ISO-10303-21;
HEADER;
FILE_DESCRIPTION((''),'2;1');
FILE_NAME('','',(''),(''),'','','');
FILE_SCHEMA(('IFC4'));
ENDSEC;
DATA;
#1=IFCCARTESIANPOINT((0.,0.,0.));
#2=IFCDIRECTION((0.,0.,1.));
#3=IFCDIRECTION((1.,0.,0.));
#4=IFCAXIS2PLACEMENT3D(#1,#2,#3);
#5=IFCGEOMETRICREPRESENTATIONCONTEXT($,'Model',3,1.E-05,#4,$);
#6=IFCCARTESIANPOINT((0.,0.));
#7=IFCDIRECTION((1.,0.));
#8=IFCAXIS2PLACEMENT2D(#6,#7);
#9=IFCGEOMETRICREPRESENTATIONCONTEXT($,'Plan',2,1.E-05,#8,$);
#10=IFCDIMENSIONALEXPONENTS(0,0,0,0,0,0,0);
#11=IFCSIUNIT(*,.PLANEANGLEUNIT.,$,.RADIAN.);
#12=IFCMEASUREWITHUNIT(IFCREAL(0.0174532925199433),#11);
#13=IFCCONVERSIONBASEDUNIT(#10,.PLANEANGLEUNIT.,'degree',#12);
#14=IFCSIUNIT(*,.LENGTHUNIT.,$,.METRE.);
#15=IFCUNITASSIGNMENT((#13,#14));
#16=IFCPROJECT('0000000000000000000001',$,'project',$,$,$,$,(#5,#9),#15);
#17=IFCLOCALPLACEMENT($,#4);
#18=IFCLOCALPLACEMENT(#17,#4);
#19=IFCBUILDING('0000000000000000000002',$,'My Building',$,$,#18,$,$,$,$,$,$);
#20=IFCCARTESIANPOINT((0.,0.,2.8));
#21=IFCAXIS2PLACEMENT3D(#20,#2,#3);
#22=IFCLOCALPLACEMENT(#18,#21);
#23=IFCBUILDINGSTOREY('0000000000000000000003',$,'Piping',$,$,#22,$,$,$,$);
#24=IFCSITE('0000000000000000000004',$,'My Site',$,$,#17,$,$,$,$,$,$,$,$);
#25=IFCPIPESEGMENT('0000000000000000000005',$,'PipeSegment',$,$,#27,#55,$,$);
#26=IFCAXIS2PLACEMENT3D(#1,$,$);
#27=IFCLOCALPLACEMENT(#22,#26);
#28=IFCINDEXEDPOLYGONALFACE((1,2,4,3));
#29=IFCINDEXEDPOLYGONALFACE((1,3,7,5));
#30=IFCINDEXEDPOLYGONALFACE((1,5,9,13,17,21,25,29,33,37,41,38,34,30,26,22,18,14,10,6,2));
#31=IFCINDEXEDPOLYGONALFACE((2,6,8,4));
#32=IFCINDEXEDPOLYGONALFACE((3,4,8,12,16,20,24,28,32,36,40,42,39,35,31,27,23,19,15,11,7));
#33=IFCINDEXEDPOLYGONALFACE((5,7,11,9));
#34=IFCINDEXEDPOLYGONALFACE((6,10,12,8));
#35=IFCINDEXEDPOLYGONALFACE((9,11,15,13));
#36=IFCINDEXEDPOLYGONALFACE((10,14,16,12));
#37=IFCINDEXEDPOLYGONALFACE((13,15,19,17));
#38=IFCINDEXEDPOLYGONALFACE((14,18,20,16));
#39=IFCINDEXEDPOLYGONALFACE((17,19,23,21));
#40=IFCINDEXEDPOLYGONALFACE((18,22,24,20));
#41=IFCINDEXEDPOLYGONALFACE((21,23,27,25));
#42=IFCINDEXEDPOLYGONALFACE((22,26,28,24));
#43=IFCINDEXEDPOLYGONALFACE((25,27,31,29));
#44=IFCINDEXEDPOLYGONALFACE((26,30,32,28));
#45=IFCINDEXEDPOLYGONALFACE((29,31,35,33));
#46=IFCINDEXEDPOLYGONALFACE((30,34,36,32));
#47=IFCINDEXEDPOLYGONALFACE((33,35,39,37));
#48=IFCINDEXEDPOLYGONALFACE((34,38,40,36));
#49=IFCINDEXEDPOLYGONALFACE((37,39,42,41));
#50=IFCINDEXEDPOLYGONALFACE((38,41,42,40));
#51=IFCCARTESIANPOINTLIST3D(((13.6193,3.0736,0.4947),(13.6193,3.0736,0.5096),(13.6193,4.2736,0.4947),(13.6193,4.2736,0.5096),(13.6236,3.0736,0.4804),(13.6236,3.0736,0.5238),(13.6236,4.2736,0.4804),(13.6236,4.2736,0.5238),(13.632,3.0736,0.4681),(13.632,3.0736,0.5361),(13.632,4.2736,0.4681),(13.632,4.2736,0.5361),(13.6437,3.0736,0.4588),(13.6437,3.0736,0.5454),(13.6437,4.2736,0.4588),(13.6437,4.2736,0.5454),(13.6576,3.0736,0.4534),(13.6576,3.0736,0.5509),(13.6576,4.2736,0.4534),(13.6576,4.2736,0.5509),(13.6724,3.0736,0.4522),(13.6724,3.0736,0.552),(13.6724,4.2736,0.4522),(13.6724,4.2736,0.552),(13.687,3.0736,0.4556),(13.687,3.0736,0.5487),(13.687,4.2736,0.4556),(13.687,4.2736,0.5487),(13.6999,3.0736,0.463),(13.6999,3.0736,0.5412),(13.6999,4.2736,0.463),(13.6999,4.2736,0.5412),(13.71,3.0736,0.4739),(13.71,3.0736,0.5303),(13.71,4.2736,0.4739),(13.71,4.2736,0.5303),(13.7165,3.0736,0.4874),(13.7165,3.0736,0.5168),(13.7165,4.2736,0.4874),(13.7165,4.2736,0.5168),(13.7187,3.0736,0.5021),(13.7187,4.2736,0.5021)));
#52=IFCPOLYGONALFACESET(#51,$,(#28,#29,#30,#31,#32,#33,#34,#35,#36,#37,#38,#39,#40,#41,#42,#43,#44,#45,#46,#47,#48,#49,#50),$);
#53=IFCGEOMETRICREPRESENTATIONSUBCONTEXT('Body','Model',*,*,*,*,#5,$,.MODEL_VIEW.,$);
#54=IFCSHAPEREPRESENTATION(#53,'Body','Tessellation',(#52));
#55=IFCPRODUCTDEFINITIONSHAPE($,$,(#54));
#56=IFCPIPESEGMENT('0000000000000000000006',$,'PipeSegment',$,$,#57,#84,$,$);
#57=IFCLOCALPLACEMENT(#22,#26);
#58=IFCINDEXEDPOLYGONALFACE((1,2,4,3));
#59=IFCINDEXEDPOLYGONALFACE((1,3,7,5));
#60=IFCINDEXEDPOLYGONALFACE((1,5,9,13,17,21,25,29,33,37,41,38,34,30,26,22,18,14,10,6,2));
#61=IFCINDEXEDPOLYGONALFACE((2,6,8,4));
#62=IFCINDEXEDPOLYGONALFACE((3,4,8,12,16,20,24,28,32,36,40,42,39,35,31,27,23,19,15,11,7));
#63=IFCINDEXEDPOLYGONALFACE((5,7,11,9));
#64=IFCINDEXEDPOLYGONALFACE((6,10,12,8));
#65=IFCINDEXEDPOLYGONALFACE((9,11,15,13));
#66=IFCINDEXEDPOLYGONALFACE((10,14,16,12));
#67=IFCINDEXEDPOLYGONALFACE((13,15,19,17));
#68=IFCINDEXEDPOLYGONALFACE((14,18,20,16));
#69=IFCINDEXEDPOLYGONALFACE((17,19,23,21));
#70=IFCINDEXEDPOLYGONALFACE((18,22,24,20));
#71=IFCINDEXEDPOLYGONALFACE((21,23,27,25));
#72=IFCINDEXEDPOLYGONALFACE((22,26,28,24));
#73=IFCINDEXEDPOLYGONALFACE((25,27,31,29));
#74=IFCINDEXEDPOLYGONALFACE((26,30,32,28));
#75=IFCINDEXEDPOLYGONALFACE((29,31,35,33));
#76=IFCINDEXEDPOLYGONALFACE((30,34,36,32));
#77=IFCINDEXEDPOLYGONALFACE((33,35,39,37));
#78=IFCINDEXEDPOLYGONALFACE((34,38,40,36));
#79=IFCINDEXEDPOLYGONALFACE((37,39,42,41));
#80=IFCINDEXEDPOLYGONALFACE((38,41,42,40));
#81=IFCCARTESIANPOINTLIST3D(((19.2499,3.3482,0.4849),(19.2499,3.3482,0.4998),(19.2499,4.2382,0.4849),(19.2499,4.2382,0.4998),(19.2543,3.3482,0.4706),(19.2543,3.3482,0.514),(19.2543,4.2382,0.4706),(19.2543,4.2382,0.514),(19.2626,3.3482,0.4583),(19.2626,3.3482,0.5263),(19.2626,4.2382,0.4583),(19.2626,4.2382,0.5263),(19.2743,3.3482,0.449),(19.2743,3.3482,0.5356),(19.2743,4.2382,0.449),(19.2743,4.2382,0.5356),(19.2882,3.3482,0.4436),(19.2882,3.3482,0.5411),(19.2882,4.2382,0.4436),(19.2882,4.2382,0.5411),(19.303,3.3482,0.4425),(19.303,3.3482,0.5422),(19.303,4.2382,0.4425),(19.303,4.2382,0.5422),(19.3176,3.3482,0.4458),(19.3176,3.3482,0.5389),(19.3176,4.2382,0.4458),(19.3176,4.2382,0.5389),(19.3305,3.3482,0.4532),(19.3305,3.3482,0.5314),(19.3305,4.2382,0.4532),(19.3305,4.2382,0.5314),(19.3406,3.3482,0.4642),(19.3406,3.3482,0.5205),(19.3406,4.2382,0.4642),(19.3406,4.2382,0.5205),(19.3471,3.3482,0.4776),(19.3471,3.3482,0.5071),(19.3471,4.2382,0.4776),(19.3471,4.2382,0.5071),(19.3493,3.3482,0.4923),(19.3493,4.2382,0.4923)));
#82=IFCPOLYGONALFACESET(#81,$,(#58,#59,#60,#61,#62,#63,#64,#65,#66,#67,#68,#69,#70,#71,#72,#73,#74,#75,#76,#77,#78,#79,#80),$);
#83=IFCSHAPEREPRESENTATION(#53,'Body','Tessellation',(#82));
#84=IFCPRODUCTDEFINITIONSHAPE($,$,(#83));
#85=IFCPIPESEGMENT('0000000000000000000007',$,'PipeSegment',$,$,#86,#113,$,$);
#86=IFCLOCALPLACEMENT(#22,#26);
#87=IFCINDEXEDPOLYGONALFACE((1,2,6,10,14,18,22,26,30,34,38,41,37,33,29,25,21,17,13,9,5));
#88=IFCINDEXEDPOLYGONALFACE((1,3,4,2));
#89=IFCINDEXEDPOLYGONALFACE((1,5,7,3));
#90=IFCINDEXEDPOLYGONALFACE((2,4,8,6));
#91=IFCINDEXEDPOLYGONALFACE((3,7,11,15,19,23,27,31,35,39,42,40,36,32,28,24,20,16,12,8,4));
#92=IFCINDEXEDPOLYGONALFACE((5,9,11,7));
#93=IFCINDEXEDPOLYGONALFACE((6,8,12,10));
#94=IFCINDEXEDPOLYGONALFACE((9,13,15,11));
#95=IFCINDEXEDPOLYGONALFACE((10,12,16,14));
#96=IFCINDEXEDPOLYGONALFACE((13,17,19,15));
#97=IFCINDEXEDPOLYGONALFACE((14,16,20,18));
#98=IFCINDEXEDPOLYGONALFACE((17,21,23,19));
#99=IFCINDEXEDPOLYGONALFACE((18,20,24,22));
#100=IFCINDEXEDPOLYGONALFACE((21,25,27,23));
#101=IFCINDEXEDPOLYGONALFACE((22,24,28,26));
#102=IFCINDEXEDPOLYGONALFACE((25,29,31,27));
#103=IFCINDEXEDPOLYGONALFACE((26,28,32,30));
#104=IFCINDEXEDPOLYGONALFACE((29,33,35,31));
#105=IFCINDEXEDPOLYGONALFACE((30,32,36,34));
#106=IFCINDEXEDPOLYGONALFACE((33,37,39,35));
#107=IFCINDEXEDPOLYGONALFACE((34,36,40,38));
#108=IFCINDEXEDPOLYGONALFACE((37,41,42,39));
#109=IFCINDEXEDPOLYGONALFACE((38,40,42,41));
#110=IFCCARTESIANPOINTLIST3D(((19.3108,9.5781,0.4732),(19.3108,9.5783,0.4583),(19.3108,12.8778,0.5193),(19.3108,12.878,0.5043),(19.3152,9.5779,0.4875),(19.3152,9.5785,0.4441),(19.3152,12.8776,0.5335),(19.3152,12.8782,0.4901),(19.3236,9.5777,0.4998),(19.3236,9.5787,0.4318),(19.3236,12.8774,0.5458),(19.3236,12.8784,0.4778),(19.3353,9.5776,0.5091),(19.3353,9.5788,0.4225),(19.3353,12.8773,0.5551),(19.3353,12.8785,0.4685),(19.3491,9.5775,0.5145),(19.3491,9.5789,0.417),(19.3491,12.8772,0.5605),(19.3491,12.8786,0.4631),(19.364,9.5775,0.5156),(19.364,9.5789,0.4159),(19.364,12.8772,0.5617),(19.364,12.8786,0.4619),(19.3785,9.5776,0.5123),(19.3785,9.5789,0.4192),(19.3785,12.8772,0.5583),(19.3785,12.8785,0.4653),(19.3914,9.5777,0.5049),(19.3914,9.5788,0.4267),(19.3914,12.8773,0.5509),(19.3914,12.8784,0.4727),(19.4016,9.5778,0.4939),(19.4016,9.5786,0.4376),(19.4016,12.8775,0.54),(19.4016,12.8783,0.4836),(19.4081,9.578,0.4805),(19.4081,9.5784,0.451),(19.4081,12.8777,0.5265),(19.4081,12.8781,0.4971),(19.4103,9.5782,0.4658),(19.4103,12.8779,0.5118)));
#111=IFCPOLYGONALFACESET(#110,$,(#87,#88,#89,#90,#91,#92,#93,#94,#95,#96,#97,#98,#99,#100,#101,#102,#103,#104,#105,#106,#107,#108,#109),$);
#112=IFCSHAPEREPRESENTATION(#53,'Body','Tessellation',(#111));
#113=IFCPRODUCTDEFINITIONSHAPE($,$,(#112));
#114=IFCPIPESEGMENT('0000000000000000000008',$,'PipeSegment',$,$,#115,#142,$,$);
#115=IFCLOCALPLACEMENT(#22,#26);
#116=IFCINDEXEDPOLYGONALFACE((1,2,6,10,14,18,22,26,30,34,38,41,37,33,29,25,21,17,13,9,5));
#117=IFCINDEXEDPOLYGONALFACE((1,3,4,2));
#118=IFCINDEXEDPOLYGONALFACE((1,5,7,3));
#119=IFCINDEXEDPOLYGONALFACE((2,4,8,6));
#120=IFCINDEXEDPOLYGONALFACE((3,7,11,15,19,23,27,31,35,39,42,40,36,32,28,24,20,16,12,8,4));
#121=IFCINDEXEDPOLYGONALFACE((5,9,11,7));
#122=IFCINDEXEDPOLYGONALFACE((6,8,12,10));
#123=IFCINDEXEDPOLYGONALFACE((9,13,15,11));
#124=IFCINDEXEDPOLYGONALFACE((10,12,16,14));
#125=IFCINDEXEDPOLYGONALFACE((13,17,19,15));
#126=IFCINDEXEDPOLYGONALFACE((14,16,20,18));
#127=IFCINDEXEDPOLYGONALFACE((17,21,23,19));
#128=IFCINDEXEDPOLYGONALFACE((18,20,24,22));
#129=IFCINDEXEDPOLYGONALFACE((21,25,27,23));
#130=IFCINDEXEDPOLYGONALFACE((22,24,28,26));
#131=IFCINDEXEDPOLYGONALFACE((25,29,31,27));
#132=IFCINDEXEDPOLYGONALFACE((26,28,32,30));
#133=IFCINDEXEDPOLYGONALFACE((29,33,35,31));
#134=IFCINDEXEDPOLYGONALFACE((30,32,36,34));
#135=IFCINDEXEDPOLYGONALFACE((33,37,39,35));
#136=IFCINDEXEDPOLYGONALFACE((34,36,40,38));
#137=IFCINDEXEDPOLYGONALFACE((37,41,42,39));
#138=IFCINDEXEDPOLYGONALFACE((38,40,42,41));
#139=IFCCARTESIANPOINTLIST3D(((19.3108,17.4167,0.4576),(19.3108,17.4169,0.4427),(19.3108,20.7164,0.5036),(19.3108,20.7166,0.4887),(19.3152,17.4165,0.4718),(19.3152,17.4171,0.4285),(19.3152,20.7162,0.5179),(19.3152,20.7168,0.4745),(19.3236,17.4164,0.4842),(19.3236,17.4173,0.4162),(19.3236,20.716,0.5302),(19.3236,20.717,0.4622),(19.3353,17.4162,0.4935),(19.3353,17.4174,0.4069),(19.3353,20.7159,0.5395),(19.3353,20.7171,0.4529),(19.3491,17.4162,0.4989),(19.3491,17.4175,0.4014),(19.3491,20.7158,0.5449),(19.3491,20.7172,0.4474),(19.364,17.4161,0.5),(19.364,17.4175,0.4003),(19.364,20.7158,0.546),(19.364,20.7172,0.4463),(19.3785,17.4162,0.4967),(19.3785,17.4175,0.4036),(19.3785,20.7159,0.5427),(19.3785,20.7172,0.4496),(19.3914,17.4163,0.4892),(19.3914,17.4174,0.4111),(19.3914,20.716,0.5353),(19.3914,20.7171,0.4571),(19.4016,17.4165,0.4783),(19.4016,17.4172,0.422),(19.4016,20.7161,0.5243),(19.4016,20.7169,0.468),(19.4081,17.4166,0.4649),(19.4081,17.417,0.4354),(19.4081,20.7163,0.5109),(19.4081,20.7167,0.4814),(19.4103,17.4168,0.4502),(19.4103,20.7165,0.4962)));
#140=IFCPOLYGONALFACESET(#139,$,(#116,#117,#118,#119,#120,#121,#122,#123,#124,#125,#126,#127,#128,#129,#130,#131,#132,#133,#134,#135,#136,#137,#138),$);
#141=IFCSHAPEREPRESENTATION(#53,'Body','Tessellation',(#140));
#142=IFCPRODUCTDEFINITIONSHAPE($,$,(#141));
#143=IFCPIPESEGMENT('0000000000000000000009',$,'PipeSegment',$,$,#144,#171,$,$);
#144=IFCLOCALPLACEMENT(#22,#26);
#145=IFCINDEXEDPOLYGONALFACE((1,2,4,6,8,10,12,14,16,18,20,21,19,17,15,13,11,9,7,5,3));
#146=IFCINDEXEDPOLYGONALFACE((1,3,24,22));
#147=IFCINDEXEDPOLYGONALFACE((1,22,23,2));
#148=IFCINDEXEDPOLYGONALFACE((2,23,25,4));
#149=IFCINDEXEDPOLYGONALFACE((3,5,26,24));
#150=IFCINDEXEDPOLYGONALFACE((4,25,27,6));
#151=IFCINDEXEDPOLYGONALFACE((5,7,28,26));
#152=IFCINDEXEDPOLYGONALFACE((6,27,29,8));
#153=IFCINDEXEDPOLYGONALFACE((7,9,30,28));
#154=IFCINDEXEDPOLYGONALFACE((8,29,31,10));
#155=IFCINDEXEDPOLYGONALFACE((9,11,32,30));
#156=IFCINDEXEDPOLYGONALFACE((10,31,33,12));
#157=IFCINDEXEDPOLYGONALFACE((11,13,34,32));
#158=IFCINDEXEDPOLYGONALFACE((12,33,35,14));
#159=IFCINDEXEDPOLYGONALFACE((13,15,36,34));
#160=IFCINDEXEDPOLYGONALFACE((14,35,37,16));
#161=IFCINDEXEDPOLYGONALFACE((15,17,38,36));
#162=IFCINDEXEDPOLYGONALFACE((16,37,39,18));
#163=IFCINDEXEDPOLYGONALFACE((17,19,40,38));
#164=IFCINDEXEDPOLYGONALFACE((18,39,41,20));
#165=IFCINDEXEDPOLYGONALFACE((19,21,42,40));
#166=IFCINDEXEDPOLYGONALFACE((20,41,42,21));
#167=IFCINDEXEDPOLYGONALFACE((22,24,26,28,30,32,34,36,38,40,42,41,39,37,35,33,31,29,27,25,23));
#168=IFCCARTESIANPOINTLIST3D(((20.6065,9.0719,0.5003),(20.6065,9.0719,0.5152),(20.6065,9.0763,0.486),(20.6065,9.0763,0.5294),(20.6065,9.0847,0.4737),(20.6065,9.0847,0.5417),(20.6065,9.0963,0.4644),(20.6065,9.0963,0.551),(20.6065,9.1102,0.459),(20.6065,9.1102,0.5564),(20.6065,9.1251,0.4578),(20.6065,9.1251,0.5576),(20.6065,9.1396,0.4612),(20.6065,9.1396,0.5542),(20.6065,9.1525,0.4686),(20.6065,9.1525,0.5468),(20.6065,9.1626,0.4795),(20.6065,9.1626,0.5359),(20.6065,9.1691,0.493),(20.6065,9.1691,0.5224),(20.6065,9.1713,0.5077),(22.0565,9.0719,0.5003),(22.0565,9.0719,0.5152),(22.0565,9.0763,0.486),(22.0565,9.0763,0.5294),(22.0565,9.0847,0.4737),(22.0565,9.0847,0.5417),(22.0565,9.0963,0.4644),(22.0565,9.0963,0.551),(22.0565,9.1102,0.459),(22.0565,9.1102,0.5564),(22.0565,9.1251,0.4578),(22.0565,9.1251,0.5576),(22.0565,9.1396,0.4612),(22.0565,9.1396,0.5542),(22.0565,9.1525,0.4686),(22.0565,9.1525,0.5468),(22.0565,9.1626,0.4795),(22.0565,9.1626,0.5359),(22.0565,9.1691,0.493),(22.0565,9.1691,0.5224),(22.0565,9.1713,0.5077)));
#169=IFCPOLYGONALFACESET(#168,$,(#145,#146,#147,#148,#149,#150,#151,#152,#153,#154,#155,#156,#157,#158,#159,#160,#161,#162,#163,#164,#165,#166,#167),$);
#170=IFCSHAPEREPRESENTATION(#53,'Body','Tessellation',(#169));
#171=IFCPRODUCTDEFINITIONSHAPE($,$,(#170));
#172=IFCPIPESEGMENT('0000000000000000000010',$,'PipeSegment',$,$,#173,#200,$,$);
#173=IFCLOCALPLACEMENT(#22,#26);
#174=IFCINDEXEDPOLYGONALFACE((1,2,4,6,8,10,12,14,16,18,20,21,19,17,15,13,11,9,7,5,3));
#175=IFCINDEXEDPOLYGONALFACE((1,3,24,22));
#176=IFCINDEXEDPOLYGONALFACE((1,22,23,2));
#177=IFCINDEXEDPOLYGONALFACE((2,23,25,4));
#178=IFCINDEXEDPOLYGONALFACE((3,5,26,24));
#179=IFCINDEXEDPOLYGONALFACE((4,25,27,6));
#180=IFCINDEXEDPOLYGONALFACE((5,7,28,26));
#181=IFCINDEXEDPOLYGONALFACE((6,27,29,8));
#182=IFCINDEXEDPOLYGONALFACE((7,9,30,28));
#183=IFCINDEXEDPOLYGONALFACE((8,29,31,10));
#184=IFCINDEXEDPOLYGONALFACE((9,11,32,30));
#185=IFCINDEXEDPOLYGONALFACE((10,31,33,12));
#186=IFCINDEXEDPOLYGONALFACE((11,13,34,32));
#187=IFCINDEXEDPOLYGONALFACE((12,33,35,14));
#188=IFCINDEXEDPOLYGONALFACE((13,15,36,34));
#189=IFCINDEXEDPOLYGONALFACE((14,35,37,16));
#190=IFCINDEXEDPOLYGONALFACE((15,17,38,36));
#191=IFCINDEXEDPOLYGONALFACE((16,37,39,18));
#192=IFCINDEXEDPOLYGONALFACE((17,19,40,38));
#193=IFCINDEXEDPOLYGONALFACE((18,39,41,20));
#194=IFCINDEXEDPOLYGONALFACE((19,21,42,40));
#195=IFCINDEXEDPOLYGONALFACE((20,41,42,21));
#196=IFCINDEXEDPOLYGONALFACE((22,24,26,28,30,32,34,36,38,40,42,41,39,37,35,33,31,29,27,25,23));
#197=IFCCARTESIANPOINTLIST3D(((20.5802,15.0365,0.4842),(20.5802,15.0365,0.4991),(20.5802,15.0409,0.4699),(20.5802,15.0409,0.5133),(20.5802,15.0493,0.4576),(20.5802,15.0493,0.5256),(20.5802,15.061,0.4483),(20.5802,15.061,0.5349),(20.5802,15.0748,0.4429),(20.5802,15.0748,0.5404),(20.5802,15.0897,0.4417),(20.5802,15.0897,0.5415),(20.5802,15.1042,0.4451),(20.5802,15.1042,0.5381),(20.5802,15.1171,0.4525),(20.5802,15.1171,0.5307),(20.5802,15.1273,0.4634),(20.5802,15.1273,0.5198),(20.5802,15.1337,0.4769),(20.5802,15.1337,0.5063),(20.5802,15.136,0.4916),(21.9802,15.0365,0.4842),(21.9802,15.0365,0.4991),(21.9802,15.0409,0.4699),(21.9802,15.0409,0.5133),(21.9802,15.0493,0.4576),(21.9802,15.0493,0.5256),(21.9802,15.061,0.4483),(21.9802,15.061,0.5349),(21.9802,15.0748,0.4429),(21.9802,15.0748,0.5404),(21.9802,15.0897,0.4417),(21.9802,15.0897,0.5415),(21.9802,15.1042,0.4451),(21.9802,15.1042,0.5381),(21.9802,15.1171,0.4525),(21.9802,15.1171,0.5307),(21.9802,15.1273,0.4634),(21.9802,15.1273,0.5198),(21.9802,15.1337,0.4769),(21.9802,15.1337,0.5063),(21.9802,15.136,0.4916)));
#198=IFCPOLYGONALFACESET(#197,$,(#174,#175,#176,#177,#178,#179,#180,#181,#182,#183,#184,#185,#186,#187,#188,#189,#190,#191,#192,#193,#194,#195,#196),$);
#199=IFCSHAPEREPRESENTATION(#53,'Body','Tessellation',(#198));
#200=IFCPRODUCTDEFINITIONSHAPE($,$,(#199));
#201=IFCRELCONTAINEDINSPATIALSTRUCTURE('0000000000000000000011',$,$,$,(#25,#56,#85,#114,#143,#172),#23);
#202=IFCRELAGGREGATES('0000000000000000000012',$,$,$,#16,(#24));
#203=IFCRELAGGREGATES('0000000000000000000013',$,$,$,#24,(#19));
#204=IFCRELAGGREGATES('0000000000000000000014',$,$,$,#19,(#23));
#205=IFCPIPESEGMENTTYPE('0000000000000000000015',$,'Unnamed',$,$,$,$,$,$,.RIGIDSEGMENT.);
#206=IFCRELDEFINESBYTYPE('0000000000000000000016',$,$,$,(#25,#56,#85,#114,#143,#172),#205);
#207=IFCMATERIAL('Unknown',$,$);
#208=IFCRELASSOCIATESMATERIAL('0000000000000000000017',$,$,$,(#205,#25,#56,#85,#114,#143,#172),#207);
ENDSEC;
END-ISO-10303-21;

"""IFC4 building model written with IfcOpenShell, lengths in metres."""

from ifc_helpers import new_model, entity, si_unit, converted_unit, frame, origin_with_axes, origin_2d_with_axis, place, context, subcontext, project, spatial, circle, extrude, material, material_profile, profile_set, profile_usage, type_object, element, save


model = new_model("IFC4")

# Units and contexts
model_context = context("Model", 3, precision=1e-05, world=origin_with_axes())
plan_context = context("Plan", 2, precision=1e-05, world=origin_2d_with_axis())
body_context = subcontext(model_context, "Body", "Model", "MODEL_VIEW")
ifc_project = project(units=[converted_unit("PLANEANGLEUNIT", "degree", entity("IfcReal", 0.0174532925199433), si_unit("PLANEANGLEUNIT", "RADIAN"), dimensions=[0, 0, 0, 0, 0, 0, 0]), si_unit("LENGTHUNIT", "METRE")], contexts=[model_context, plan_context])

# Site, building, storey
site_placement = place(None, origin_with_axes())
site = spatial("IfcSite", under=ifc_project, at=site_placement, Name="My Site")
building_placement = place(site_placement, origin_with_axes())
building = spatial("IfcBuilding", under=site, at=building_placement, Name="My Building")
storey_placement = place(building_placement, frame((0.0, 0.0, 2.8), z_axis=(0.0, 0.0, 1.0), x_axis=(1.0, 0.0, 0.0)))
storey = spatial("IfcBuildingStorey", under=building, at=storey_placement, Name="Piping")

# Pipe segments
ifc_material = material(Name="Unknown")
ifc_material_profile_1 = material_profile(ifc_material, circle(Radius=0.05))
ifc_profile_set_1 = profile_set([ifc_material_profile_1])
pipe_segment_type = type_object("IfcPipeSegmentType", Name="Unnamed", PredefinedType="RIGIDSEGMENT", material=ifc_profile_set_1)
ifc_profile_usage_1 = profile_usage(ifc_profile_set_1, cardinal=5)
pipe_segment_1_placement = place(storey_placement, frame((13.6687, 4.2736, 0.5021), z_axis=(0.0, -1.0, 0.0), x_axis=(1.0, 0.0, 0.0)))
element("IfcPipeSegment", 1, at=pipe_segment_1_placement, inside=storey, type_object=pipe_segment_type, material=ifc_profile_usage_1, Name="PipeSegment", context=body_context, shape_type="SweptSolid", body=[
    extrude(circle(Radius=0.05), origin_with_axes(), (0.0, 0.0, 1.0), 1.2),
])
ifc_profile_usage_2 = profile_usage(ifc_profile_set_1, cardinal=5)
pipe_segment_2_placement = place(storey_placement, frame((19.2993, 4.2382, 0.4923), z_axis=(0.0, -1.0, 0.0), x_axis=(1.0, 0.0, 0.0)))
element("IfcPipeSegment", 2, at=pipe_segment_2_placement, inside=storey, type_object=pipe_segment_type, material=ifc_profile_usage_2, Name="PipeSegment", context=body_context, shape_type="SweptSolid", body=[
    extrude(circle(Radius=0.05), origin_with_axes(), (0.0, 0.0, 1.0), 0.89),
])
ifc_profile_usage_3 = profile_usage(ifc_profile_set_1, cardinal=5)
pipe_segment_3_placement = place(storey_placement, frame((19.3603, 12.8779, 0.5118), z_axis=(0.0, -0.999903, -0.013947), x_axis=(1.0, 0.0, 0.0)))
element("IfcPipeSegment", 3, at=pipe_segment_3_placement, inside=storey, type_object=pipe_segment_type, material=ifc_profile_usage_3, Name="PipeSegment", context=body_context, shape_type="SweptSolid", body=[
    extrude(circle(Radius=0.05), origin_with_axes(), (0.0, 0.0, 1.0), 3.3),
])
ifc_profile_usage_4 = profile_usage(ifc_profile_set_1, cardinal=5)
pipe_segment_4_placement = place(storey_placement, frame((19.3603, 20.7165, 0.4962), z_axis=(0.0, -0.999903, -0.013947), x_axis=(1.0, 0.0, 0.0)))
element("IfcPipeSegment", 4, at=pipe_segment_4_placement, inside=storey, type_object=pipe_segment_type, material=ifc_profile_usage_4, Name="PipeSegment", context=body_context, shape_type="SweptSolid", body=[
    extrude(circle(Radius=0.05), origin_with_axes(), (0.0, 0.0, 1.0), 3.3),
])
ifc_profile_usage_5 = profile_usage(ifc_profile_set_1, cardinal=5)
pipe_segment_5_placement = place(storey_placement, frame((20.6065, 9.1213, 0.5077), z_axis=(1.0, 0.0, 0.0), x_axis=(0.0, 1.0, 0.0)))
element("IfcPipeSegment", 5, at=pipe_segment_5_placement, inside=storey, type_object=pipe_segment_type, material=ifc_profile_usage_5, Name="PipeSegment", context=body_context, shape_type="SweptSolid", body=[
    extrude(circle(Radius=0.05), origin_with_axes(), (0.0, 0.0, 1.0), 1.45),
])
ifc_profile_usage_6 = profile_usage(ifc_profile_set_1, cardinal=5)
pipe_segment_6_placement = place(storey_placement, frame((20.5802, 15.086, 0.4916), z_axis=(1.0, 0.0, 0.0), x_axis=(0.0, 1.0, 0.0)))
element("IfcPipeSegment", 6, at=pipe_segment_6_placement, inside=storey, type_object=pipe_segment_type, material=ifc_profile_usage_6, Name="PipeSegment", context=body_context, shape_type="SweptSolid", body=[
    extrude(circle(Radius=0.05), origin_with_axes(), (0.0, 0.0, 1.0), 1.4),
])

save(model, "model.ifc")
